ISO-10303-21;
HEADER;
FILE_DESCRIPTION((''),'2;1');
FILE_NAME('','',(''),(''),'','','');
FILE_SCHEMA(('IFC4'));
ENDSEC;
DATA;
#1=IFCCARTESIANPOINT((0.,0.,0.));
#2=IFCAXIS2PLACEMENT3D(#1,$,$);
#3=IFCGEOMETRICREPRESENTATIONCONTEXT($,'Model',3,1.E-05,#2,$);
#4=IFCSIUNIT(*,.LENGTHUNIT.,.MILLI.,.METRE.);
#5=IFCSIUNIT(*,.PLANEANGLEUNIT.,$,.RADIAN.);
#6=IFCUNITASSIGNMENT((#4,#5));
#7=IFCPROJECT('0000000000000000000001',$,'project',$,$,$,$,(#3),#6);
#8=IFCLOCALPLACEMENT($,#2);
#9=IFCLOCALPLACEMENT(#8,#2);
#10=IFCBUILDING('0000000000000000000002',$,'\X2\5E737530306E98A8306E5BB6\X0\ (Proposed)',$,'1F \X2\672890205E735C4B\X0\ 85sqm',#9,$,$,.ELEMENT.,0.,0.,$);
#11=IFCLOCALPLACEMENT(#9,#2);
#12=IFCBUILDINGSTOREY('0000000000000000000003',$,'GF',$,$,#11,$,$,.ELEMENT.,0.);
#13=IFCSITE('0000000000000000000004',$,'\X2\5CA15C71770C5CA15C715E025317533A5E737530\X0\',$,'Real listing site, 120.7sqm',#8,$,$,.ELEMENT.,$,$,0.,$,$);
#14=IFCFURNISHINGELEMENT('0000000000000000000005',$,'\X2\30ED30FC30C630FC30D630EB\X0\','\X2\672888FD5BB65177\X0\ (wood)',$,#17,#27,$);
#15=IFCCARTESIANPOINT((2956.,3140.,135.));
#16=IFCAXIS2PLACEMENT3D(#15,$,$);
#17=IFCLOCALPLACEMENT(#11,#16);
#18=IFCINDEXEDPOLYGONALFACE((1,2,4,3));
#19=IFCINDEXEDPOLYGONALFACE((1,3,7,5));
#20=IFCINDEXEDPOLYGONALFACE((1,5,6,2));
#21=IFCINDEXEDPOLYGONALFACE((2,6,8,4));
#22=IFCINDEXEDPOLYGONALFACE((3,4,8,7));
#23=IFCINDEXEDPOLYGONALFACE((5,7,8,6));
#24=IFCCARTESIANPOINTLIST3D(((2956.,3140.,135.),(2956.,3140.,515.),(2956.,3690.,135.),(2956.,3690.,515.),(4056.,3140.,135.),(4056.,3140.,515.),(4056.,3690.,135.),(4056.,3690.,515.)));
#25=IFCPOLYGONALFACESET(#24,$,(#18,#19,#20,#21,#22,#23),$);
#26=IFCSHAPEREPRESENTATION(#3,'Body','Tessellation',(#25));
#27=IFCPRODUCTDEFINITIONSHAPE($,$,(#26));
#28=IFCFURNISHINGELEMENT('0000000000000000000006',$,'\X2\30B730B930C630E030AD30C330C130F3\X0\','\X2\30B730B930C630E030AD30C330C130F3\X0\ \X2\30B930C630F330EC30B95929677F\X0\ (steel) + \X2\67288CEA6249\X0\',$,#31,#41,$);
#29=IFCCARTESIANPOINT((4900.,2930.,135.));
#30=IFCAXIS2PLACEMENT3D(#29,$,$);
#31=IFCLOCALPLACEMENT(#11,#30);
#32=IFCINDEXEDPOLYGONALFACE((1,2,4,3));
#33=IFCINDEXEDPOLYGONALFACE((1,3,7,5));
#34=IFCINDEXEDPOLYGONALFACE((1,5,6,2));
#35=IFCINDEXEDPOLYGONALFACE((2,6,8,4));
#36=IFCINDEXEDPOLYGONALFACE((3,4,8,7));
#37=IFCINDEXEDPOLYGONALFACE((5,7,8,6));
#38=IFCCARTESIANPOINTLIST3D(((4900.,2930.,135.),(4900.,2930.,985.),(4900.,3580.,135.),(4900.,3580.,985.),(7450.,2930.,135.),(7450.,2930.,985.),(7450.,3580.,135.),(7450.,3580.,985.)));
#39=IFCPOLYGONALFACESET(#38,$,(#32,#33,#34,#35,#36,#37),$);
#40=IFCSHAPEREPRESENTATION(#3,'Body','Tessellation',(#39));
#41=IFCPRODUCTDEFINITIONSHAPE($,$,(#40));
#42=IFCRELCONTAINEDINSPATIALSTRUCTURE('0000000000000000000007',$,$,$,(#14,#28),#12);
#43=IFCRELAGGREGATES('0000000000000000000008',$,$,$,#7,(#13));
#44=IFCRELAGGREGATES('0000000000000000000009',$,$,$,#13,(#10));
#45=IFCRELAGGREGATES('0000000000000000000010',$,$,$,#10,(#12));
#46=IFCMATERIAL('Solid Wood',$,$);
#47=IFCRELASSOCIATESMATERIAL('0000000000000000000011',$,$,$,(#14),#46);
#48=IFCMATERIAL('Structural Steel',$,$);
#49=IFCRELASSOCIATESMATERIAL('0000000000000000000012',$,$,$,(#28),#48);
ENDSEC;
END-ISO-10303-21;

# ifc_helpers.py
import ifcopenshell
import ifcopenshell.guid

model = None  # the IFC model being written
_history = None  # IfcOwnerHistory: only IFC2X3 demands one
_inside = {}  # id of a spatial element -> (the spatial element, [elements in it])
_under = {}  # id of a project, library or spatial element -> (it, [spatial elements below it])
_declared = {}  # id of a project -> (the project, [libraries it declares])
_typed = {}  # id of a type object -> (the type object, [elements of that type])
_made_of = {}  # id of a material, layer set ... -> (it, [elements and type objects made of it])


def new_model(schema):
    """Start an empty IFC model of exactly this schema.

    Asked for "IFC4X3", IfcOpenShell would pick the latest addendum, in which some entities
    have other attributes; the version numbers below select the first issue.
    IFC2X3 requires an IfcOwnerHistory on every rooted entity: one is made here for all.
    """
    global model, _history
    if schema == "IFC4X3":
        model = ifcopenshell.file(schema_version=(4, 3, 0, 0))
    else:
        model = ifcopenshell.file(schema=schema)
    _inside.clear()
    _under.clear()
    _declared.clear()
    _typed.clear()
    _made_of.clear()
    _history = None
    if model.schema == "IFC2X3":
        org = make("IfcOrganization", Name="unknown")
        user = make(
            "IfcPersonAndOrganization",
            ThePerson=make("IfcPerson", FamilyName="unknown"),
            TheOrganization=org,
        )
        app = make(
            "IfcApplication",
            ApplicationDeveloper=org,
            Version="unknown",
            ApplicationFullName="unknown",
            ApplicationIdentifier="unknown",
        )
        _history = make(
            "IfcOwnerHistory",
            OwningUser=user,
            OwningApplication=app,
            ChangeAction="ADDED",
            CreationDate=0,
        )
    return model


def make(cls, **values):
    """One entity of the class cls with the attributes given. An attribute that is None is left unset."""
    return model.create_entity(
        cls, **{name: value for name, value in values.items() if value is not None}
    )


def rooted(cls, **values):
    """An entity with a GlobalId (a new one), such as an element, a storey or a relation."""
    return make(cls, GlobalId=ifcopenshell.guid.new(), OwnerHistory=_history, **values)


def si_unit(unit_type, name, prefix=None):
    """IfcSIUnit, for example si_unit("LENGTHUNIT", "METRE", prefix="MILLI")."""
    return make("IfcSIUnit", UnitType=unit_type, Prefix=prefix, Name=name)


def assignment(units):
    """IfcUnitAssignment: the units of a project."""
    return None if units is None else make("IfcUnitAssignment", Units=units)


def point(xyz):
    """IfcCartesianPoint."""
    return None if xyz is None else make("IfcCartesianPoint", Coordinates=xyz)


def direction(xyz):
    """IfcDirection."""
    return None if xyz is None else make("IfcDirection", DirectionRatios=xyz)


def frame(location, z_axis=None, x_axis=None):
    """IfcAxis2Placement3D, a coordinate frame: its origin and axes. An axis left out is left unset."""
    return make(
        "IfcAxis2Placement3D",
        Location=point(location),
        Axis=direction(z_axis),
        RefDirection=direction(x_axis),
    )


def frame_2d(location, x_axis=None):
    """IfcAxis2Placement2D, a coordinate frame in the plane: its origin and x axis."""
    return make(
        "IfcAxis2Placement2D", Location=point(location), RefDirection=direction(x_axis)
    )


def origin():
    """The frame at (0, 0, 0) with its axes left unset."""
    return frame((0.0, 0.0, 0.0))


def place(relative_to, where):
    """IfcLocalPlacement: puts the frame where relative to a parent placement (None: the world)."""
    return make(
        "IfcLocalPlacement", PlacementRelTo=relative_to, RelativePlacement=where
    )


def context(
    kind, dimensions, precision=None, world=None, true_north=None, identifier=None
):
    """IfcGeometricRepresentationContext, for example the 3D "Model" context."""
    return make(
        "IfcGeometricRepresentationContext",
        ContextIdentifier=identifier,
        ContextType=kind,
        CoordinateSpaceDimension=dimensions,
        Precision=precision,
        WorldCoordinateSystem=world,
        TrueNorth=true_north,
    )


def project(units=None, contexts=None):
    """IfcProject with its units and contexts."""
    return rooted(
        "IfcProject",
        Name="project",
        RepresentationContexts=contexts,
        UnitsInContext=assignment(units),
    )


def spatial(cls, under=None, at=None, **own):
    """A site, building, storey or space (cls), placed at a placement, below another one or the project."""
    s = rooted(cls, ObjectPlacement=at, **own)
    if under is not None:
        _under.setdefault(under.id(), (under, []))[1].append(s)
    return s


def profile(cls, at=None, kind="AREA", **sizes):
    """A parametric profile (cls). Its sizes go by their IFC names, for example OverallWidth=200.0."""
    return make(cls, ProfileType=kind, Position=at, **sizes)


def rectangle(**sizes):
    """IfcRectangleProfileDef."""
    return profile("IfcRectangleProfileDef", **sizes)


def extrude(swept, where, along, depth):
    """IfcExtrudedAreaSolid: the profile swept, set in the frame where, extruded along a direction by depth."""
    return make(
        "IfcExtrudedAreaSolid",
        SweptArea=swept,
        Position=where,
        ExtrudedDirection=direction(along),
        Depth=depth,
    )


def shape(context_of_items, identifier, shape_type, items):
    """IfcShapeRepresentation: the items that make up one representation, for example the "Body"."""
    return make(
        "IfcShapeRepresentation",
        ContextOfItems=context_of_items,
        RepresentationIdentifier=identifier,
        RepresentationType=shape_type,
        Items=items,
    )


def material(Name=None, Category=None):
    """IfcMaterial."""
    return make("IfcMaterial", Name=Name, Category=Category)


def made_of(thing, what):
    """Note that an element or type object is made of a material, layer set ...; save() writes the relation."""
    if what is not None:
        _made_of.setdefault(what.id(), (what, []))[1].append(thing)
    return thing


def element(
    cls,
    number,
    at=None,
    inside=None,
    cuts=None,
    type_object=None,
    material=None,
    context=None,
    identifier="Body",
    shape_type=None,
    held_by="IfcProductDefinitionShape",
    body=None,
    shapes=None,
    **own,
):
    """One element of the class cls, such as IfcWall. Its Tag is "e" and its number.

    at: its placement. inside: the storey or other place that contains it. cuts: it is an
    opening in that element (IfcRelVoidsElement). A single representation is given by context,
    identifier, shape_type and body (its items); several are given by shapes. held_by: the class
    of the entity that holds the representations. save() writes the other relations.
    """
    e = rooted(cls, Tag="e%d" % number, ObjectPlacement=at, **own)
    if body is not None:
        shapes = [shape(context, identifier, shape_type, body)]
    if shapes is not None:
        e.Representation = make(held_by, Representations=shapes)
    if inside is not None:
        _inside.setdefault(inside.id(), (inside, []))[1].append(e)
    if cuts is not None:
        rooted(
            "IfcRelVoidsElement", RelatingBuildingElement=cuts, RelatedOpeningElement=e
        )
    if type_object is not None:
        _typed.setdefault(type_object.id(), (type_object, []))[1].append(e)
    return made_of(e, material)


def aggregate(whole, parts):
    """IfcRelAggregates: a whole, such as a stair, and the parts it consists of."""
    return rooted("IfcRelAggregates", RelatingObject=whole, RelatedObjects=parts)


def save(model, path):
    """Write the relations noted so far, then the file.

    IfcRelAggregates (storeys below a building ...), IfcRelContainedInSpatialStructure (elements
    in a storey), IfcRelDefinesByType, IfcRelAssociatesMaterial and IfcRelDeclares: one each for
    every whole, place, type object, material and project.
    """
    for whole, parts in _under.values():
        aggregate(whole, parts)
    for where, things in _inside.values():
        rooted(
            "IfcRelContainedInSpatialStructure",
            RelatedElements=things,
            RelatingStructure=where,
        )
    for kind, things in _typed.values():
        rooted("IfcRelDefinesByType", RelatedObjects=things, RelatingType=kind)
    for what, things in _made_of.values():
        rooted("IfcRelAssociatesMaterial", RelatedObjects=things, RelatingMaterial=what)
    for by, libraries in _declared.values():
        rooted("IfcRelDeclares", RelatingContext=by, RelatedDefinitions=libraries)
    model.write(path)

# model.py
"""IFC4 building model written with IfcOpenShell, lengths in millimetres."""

from ifc_helpers import new_model, si_unit, frame, frame_2d, origin, place, context, project, spatial, rectangle, extrude, material, element, save


model = new_model("IFC4")

# Units and contexts
model_context = context("Model", 3, precision=1e-05, world=origin())
ifc_project = project(units=[si_unit("LENGTHUNIT", "METRE", prefix="MILLI"), si_unit("PLANEANGLEUNIT", "RADIAN")], contexts=[model_context])

# Site, building, storey
site_placement = place(None, origin())
site = spatial("IfcSite", under=ifc_project, at=site_placement, Name="岡山県岡山市北区平田", ObjectType="Real listing site, 120.7sqm", CompositionType="ELEMENT", RefElevation=0.0)
building_placement = place(site_placement, origin())
building = spatial("IfcBuilding", under=site, at=building_placement, Name="平田の風の家 (Proposed)", ObjectType="1F 木造平屋 85sqm", CompositionType="ELEMENT", ElevationOfRefHeight=0.0, ElevationOfTerrain=0.0)
storey_placement = place(building_placement, origin())
storey = spatial("IfcBuildingStorey", under=building, at=storey_placement, Name="GF", CompositionType="ELEMENT", Elevation=0.0)

# Shared definitions
ifc_material_1 = material(Name="Solid Wood")

# Furnishing elements
furnishing_1_placement = place(storey_placement, frame((2956.0, 3140.0, 135.0)))
element("IfcFurnishingElement", 1, at=furnishing_1_placement, inside=storey, material=ifc_material_1, Name="ローテーブル", Description="木製家具 (wood)", context=model_context, shape_type="SweptSolid", body=[
    extrude(rectangle(XDim=1100.0, YDim=550.0, at=frame_2d((550.0, 275.0))), frame((2956.0, 3140.0, 135.0)), (0.0, 0.0, 1.0), 380.0),
])
ifc_material_2 = material(Name="Structural Steel")
furnishing_2_placement = place(storey_placement, frame((4900.0, 2930.0, 135.0)))
element("IfcFurnishingElement", 2, at=furnishing_2_placement, inside=storey, material=ifc_material_2, Name="システムキッチン", Description="システムキッチン ステンレス天板 (steel) + 木質扉", context=model_context, shape_type="SweptSolid", body=[
    extrude(rectangle(XDim=2550.0, YDim=650.0, at=frame_2d((1275.0, 325.0))), frame((4900.0, 2930.0, 135.0)), (0.0, 0.0, 1.0), 850.0),
])

save(model, "model.ifc")
